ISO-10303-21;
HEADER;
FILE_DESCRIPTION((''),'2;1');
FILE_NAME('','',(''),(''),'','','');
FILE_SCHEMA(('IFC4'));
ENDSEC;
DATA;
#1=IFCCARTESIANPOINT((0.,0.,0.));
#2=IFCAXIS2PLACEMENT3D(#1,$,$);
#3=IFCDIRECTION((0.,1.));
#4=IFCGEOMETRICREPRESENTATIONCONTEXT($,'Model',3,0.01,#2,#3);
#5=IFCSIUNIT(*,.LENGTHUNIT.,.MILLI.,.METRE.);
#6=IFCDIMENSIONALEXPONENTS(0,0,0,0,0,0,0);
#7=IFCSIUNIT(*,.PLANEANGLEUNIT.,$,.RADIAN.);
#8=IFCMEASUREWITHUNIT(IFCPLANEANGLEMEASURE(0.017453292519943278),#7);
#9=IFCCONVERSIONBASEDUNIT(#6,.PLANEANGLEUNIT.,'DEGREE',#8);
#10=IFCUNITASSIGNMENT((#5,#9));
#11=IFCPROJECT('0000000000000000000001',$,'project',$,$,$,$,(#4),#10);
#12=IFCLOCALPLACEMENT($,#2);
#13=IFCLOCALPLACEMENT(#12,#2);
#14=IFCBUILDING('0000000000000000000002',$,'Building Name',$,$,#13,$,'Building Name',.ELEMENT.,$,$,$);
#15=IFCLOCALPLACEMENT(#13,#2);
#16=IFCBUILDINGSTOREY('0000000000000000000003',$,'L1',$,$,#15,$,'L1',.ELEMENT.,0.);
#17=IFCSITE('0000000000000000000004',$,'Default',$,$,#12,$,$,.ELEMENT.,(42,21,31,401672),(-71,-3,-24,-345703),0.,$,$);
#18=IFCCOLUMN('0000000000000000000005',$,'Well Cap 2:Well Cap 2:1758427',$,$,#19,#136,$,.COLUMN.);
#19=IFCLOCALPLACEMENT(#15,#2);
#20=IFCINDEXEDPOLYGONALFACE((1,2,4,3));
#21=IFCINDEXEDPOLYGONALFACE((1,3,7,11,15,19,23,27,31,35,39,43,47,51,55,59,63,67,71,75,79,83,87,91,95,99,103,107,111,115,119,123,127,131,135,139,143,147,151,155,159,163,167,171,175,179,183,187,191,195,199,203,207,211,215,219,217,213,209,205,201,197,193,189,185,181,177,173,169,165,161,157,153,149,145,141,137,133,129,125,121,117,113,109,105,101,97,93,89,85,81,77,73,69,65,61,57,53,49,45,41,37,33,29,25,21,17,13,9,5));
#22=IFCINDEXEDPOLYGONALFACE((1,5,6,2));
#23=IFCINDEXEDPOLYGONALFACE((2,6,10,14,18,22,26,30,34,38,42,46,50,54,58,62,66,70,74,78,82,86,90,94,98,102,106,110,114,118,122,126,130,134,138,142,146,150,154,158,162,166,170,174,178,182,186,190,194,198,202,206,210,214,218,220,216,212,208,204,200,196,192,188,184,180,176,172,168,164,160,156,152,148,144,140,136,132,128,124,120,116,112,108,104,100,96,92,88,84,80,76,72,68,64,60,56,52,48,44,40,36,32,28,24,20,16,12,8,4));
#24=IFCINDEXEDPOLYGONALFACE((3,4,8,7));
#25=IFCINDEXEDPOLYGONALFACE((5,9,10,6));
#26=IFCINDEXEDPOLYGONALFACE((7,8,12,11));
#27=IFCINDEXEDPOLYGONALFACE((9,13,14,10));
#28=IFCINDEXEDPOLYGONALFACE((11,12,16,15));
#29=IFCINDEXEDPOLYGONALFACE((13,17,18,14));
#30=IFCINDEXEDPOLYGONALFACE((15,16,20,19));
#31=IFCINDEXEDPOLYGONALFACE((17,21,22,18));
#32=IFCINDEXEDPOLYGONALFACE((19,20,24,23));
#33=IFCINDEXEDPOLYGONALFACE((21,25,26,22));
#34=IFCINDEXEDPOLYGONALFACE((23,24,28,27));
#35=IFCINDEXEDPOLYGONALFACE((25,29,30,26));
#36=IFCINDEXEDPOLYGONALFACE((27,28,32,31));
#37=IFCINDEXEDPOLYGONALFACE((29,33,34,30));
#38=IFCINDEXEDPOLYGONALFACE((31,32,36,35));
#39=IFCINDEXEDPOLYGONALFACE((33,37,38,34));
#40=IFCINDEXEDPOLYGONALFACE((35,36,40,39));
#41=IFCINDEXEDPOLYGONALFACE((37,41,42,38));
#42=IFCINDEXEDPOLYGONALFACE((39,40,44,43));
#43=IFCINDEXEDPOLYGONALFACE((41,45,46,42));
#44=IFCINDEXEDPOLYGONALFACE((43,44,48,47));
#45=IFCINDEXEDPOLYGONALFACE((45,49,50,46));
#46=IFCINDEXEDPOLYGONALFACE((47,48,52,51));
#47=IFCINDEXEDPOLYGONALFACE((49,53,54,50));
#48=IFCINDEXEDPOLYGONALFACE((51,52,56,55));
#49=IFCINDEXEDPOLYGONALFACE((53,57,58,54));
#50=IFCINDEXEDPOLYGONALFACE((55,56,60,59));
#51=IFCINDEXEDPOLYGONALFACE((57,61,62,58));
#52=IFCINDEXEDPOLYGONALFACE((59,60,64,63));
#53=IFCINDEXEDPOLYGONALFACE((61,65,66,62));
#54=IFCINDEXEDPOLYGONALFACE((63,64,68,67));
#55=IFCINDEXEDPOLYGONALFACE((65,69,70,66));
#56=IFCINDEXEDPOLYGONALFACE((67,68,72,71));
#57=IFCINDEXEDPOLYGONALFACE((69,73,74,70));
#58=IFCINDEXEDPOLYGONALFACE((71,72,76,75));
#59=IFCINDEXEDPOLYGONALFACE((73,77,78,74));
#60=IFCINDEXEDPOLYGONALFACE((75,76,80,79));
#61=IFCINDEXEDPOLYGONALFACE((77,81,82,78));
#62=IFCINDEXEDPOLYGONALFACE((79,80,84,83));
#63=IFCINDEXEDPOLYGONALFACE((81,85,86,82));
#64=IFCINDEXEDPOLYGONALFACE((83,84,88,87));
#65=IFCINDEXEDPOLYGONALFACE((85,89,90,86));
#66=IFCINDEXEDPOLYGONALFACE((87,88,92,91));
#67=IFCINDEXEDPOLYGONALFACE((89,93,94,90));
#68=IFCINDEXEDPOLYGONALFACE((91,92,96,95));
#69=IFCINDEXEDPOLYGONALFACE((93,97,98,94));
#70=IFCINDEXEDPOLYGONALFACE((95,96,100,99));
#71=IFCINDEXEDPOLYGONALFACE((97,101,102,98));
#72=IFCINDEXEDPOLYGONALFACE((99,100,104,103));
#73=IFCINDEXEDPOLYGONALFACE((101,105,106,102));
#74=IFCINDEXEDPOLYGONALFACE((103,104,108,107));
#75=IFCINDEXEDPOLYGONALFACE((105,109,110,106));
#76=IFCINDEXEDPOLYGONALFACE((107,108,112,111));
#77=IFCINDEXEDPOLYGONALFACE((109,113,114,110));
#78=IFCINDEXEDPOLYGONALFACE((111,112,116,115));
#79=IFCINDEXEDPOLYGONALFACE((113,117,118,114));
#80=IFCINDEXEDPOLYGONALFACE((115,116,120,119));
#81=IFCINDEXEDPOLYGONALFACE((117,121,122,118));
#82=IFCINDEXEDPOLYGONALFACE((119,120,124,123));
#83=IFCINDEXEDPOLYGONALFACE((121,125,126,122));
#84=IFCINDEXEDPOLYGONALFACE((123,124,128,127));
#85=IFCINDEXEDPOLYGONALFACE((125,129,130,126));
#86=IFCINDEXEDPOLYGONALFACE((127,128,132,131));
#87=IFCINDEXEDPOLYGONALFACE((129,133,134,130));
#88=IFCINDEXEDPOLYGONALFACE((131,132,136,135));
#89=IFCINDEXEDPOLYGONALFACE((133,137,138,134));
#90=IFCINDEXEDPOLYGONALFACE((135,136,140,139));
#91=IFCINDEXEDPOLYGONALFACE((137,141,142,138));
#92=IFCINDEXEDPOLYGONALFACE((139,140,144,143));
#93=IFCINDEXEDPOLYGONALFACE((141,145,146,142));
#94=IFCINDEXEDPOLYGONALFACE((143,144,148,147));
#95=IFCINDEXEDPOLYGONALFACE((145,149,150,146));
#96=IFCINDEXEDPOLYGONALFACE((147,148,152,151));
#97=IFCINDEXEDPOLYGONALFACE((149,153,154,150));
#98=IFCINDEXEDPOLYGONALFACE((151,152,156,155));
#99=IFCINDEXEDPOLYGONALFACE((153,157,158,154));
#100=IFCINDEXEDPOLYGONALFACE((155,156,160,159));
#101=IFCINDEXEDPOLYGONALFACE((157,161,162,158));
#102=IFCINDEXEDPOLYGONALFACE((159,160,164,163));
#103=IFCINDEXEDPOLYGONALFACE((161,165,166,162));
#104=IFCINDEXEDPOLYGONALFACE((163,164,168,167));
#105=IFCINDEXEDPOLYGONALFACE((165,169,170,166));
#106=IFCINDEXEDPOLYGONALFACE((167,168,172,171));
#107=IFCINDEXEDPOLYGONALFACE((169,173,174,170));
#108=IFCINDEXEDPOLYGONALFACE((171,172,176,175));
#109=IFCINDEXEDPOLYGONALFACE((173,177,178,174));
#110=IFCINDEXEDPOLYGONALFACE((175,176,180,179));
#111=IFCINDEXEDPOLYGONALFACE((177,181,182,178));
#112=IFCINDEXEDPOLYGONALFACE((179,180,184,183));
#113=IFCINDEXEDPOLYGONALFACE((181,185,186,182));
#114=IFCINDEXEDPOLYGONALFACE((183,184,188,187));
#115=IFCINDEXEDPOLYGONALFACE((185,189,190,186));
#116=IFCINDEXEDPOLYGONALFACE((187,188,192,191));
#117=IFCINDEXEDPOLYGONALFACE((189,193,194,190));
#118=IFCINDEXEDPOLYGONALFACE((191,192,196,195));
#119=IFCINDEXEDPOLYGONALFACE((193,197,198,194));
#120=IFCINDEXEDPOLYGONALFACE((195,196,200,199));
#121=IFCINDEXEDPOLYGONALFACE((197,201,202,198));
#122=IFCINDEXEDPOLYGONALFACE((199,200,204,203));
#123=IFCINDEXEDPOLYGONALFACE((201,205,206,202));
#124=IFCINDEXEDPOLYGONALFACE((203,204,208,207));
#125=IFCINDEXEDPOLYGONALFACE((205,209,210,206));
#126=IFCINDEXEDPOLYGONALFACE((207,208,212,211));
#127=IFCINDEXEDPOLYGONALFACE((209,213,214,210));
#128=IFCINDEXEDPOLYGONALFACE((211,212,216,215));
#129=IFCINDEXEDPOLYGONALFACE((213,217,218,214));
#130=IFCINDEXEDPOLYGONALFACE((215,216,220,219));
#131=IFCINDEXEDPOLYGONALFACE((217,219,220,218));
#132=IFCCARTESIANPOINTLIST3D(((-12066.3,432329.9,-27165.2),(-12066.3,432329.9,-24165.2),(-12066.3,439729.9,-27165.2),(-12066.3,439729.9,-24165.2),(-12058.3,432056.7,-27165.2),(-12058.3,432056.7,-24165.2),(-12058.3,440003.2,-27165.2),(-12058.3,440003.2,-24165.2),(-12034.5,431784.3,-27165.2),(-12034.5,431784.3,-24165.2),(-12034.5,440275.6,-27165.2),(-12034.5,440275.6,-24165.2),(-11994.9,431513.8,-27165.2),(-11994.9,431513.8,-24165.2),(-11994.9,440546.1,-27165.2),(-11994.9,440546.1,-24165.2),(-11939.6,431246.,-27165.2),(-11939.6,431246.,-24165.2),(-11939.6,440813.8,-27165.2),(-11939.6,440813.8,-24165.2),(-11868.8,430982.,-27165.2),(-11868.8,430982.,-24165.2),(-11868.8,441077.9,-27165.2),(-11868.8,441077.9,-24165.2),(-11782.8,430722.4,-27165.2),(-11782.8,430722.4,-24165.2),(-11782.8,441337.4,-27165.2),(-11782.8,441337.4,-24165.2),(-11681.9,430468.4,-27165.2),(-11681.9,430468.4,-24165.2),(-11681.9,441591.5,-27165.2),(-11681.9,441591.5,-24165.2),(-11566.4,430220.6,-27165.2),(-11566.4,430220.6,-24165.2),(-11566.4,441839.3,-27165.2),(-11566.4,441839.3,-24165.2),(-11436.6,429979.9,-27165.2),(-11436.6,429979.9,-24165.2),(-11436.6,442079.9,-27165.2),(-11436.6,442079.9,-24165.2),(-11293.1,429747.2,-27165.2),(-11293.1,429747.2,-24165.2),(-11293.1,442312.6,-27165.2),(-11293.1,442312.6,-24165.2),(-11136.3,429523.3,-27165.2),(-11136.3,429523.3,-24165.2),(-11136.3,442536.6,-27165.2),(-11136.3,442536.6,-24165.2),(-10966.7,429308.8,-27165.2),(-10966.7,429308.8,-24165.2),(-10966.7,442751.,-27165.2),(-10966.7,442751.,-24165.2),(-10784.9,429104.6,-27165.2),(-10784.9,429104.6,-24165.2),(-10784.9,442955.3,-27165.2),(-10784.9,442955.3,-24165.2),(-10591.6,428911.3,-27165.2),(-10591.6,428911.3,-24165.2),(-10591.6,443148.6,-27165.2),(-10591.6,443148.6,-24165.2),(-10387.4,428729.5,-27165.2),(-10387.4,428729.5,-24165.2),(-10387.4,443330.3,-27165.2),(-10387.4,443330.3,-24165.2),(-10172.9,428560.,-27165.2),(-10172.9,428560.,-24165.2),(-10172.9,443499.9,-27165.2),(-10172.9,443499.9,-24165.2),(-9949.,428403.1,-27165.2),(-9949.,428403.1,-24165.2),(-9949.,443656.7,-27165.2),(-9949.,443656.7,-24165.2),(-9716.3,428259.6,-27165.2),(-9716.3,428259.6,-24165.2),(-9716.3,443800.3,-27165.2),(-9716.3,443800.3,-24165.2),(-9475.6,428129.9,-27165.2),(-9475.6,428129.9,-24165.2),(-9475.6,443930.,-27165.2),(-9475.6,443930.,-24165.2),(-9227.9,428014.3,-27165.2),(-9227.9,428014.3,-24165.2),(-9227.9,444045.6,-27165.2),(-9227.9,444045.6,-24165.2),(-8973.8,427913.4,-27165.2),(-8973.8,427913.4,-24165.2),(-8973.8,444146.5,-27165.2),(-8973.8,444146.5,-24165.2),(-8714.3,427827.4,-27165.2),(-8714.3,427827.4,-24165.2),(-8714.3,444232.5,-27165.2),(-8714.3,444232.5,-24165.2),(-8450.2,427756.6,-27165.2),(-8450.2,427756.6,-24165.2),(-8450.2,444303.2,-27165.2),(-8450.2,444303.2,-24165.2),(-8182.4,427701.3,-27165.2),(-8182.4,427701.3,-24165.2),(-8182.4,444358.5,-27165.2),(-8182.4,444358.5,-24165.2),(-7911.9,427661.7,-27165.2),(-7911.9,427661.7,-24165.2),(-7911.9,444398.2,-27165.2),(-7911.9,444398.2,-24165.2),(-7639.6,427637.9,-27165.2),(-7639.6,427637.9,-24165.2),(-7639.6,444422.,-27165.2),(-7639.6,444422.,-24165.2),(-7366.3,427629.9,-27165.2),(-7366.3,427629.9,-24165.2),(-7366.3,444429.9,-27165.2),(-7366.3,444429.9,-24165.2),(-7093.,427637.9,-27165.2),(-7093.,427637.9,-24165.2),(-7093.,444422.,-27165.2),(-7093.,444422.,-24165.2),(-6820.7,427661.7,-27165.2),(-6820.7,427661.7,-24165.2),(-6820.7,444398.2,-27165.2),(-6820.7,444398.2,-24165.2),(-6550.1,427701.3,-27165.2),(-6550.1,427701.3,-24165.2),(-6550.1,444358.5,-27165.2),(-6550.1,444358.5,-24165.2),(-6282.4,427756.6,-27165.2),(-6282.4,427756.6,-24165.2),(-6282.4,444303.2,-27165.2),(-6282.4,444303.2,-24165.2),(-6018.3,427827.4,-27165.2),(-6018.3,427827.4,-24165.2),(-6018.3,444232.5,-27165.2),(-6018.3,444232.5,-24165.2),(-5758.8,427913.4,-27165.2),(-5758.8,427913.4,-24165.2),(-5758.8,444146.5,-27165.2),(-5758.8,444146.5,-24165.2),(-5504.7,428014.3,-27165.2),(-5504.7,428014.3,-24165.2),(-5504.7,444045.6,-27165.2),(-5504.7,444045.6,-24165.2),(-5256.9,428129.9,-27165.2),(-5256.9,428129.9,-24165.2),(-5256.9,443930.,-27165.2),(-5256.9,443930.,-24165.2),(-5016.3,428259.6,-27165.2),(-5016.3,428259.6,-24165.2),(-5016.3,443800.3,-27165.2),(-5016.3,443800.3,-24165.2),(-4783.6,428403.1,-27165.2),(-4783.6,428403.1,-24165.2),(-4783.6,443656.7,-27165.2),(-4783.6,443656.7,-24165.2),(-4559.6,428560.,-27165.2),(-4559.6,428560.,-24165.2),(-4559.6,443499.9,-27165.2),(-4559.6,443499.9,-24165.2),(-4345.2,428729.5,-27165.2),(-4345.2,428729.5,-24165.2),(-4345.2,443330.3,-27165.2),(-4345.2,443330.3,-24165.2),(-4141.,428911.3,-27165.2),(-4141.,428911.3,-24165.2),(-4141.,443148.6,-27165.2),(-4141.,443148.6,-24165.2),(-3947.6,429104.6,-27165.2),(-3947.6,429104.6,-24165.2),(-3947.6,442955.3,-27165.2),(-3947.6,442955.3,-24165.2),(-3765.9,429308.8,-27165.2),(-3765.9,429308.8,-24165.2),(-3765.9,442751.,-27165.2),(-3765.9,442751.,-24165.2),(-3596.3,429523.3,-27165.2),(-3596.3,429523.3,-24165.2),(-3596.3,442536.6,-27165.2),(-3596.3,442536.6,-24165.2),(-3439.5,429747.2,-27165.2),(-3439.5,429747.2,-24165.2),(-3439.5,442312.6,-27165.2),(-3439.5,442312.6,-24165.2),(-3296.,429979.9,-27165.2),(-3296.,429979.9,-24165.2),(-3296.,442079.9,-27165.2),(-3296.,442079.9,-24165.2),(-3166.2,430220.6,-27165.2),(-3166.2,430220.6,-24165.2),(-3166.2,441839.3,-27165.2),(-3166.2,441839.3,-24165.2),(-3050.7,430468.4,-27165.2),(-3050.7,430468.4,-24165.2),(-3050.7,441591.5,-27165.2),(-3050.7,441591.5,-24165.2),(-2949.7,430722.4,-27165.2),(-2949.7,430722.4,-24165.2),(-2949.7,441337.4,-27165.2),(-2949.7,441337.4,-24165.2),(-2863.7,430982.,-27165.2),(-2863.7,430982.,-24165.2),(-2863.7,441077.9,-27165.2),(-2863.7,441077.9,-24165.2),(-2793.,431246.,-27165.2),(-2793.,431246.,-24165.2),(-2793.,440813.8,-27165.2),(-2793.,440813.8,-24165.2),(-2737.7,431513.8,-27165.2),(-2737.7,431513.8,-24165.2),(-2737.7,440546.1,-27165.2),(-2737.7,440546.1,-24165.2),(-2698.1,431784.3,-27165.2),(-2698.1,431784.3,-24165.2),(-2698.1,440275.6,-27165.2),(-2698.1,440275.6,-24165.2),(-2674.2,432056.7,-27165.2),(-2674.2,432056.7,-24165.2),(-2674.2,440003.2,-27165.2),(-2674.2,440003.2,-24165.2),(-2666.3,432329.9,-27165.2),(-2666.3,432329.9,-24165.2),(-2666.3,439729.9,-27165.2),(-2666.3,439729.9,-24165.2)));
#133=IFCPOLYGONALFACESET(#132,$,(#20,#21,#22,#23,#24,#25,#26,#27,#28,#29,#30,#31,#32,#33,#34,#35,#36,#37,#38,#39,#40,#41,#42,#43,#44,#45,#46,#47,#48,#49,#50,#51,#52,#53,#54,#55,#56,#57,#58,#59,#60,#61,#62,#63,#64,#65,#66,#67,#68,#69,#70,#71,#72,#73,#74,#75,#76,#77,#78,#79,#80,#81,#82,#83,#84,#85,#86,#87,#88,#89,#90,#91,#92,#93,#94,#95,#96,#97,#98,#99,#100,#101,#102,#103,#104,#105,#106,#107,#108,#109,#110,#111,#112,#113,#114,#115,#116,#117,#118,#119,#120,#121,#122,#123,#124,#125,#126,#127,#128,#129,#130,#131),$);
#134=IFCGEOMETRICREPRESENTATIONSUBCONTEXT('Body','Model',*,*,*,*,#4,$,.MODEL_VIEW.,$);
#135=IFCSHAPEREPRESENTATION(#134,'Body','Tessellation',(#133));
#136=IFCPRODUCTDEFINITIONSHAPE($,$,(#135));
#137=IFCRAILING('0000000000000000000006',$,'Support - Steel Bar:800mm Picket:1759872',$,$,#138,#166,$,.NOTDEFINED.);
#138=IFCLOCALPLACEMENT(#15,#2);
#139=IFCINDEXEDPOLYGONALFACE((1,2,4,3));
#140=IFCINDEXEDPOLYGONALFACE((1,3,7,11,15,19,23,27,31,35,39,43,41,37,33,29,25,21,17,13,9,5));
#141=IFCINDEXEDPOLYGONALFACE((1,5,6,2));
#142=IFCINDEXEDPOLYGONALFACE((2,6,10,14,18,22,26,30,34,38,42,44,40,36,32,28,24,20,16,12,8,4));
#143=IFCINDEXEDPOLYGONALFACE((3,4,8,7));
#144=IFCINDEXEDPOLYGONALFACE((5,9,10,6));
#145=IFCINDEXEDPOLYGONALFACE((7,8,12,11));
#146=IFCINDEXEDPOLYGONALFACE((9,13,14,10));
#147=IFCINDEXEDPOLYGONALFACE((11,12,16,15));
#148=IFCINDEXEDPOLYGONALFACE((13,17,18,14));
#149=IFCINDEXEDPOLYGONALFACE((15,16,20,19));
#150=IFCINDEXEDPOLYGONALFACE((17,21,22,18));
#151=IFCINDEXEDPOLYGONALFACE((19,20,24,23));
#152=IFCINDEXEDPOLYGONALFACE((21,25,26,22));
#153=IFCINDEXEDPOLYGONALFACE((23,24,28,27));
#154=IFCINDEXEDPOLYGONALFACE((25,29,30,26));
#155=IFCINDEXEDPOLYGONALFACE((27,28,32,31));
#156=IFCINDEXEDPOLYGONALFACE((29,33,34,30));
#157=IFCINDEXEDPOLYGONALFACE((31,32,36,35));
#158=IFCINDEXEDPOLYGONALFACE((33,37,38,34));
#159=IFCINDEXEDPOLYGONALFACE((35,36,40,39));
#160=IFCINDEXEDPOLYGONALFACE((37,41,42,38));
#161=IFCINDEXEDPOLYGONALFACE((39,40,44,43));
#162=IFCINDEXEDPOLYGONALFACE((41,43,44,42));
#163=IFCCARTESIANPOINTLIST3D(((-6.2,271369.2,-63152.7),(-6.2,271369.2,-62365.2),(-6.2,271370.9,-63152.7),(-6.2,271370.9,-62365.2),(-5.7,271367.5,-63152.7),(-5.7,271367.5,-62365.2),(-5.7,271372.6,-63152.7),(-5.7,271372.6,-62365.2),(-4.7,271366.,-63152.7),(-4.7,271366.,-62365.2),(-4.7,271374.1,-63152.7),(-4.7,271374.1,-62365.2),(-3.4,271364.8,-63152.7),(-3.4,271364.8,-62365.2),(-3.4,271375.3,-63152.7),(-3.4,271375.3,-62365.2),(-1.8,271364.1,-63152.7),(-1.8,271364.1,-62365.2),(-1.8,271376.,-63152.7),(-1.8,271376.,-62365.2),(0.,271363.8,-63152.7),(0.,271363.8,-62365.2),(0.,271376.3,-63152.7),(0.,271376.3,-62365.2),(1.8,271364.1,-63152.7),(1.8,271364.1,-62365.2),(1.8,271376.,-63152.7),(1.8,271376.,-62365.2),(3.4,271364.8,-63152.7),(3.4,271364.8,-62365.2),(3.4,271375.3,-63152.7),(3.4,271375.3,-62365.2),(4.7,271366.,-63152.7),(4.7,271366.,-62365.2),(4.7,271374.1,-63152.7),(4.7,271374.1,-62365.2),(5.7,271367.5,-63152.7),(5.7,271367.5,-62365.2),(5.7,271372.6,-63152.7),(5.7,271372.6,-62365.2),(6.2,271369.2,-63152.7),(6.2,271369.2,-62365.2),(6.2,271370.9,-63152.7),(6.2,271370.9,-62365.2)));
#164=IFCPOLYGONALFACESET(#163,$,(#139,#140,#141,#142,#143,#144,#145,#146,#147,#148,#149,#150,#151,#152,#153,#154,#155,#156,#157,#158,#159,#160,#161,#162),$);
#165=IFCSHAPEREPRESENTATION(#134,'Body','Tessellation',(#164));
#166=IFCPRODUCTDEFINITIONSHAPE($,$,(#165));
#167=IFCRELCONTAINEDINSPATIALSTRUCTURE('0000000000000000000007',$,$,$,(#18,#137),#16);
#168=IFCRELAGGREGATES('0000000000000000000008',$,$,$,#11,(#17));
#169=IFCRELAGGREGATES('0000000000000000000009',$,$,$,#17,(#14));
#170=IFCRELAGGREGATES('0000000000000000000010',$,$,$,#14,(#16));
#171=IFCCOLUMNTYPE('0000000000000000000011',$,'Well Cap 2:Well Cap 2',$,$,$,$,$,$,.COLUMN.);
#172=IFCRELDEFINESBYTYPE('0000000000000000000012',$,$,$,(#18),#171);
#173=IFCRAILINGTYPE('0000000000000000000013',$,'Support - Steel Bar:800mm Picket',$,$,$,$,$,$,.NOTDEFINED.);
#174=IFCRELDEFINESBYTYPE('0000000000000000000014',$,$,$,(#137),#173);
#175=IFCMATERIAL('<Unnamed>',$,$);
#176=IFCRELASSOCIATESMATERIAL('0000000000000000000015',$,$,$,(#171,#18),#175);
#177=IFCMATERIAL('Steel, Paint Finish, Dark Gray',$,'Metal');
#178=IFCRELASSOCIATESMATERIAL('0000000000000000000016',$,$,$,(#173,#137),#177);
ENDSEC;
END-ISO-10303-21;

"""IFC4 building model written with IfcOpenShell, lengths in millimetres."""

from ifc_helpers import new_model, entity, si_unit, converted_unit, direction, frame, origin, place, context, subcontext, project, spatial, line, arc, indexed_curve, outline, extrude, source, transform, mapped, material, type_object, type_shapes, element, save


model = new_model("IFC4")

# Units and contexts
model_context = context("Model", 3, precision=0.01, world=origin(), true_north=direction((0.0, 1.0)))
body_context = subcontext(model_context, "Body", "Model", "MODEL_VIEW")
ifc_project = project(units=[si_unit("LENGTHUNIT", "METRE", prefix="MILLI"), converted_unit("PLANEANGLEUNIT", "DEGREE", entity("IfcPlaneAngleMeasure", 0.017453292519943278), si_unit("PLANEANGLEUNIT", "RADIAN"), dimensions=[0, 0, 0, 0, 0, 0, 0])], contexts=[model_context])

# Site, building, storey
site_placement = place(None, origin())
site = spatial("IfcSite", under=ifc_project, at=site_placement, Name="Default", CompositionType="ELEMENT", RefLatitude=(42, 21, 31, 401672), RefLongitude=(-71, -3, -24, -345703), RefElevation=0.0)
building_placement = place(site_placement, origin())
building = spatial("IfcBuilding", under=site, at=building_placement, Name="Building Name", LongName="Building Name", CompositionType="ELEMENT")
storey_placement = place(building_placement, origin())
storey = spatial("IfcBuildingStorey", under=building, at=storey_placement, Name="L1", LongName="L1", CompositionType="ELEMENT", Elevation=0.0)

# Column
ifc_material_1 = material(Name="<Unnamed>")
column_type_1 = type_object("IfcColumnType", Name="Well Cap 2:Well Cap 2", PredefinedType="COLUMN", material=ifc_material_1)
shared_shape_1 = source(origin(), body_context, "Body", "SweptSolid", [
    extrude(outline(indexed_curve([(-3700.0, -4700.0), (3700.0, -4700.0), (8400.0, 0.0), (3700.0, 4700.0), (-3700.0, 4700.0), (-8400.0, 0.0)], segments=[line(1, 2), arc(2, 3, 4), line(4, 5), arc(5, 6, 1)], self_intersect=False)), frame((8064.3, 0.0, 0.0), z_axis=(0.0, 0.0, 1.0), x_axis=(0.0, -1.0, 0.0)), (0.0, 0.0, 1.0), 3000.0),
])
type_shapes(column_type_1, [shared_shape_1])
column_1_placement = place(storey_placement, frame((-15430.5, 436029.9, -27165.2)))
element("IfcColumn", 1, at=column_1_placement, inside=storey, type_object=column_type_1, material=ifc_material_1, Name="Well Cap 2:Well Cap 2:1758427", PredefinedType="COLUMN", context=body_context, shape_type="MappedRepresentation", body=[
    mapped(shared_shape_1, transform((0.0, 0.0, 0.0), scale=1.0)),
])

# Railing
ifc_material_2 = material(Name="Steel, Paint Finish, Dark Gray", Category="Metal")
railing_type = type_object("IfcRailingType", Name="Support - Steel Bar:800mm Picket", PredefinedType="NOTDEFINED", material=ifc_material_2)
shared_shape_2 = source(origin(), body_context, "Body", "SweptSolid", [
    extrude(outline(indexed_curve([(-6.2, 0.0), (0.0, -6.3), (6.2, 0.0), (0.0, 6.2)], segments=[arc(1, 2, 3), arc(3, 4, 1)], self_intersect=False)), frame((0.0, 0.0, 12.5), z_axis=(0.0, 0.0, 1.0), x_axis=(0.0, 1.0, 0.0)), (0.0, 0.0, 1.0), 787.5),
])
type_shapes(railing_type, [shared_shape_2])
railing_placement = place(storey_placement, frame((0.0, 271370.0, -63165.2)))
element("IfcRailing", 2, at=railing_placement, inside=storey, type_object=railing_type, material=ifc_material_2, Name="Support - Steel Bar:800mm Picket:1759872", PredefinedType="NOTDEFINED", context=body_context, shape_type="MappedRepresentation", body=[
    mapped(shared_shape_2, transform((0.0, 0.0, 0.0), scale=1.0)),
])

save(model, "model.ifc")
